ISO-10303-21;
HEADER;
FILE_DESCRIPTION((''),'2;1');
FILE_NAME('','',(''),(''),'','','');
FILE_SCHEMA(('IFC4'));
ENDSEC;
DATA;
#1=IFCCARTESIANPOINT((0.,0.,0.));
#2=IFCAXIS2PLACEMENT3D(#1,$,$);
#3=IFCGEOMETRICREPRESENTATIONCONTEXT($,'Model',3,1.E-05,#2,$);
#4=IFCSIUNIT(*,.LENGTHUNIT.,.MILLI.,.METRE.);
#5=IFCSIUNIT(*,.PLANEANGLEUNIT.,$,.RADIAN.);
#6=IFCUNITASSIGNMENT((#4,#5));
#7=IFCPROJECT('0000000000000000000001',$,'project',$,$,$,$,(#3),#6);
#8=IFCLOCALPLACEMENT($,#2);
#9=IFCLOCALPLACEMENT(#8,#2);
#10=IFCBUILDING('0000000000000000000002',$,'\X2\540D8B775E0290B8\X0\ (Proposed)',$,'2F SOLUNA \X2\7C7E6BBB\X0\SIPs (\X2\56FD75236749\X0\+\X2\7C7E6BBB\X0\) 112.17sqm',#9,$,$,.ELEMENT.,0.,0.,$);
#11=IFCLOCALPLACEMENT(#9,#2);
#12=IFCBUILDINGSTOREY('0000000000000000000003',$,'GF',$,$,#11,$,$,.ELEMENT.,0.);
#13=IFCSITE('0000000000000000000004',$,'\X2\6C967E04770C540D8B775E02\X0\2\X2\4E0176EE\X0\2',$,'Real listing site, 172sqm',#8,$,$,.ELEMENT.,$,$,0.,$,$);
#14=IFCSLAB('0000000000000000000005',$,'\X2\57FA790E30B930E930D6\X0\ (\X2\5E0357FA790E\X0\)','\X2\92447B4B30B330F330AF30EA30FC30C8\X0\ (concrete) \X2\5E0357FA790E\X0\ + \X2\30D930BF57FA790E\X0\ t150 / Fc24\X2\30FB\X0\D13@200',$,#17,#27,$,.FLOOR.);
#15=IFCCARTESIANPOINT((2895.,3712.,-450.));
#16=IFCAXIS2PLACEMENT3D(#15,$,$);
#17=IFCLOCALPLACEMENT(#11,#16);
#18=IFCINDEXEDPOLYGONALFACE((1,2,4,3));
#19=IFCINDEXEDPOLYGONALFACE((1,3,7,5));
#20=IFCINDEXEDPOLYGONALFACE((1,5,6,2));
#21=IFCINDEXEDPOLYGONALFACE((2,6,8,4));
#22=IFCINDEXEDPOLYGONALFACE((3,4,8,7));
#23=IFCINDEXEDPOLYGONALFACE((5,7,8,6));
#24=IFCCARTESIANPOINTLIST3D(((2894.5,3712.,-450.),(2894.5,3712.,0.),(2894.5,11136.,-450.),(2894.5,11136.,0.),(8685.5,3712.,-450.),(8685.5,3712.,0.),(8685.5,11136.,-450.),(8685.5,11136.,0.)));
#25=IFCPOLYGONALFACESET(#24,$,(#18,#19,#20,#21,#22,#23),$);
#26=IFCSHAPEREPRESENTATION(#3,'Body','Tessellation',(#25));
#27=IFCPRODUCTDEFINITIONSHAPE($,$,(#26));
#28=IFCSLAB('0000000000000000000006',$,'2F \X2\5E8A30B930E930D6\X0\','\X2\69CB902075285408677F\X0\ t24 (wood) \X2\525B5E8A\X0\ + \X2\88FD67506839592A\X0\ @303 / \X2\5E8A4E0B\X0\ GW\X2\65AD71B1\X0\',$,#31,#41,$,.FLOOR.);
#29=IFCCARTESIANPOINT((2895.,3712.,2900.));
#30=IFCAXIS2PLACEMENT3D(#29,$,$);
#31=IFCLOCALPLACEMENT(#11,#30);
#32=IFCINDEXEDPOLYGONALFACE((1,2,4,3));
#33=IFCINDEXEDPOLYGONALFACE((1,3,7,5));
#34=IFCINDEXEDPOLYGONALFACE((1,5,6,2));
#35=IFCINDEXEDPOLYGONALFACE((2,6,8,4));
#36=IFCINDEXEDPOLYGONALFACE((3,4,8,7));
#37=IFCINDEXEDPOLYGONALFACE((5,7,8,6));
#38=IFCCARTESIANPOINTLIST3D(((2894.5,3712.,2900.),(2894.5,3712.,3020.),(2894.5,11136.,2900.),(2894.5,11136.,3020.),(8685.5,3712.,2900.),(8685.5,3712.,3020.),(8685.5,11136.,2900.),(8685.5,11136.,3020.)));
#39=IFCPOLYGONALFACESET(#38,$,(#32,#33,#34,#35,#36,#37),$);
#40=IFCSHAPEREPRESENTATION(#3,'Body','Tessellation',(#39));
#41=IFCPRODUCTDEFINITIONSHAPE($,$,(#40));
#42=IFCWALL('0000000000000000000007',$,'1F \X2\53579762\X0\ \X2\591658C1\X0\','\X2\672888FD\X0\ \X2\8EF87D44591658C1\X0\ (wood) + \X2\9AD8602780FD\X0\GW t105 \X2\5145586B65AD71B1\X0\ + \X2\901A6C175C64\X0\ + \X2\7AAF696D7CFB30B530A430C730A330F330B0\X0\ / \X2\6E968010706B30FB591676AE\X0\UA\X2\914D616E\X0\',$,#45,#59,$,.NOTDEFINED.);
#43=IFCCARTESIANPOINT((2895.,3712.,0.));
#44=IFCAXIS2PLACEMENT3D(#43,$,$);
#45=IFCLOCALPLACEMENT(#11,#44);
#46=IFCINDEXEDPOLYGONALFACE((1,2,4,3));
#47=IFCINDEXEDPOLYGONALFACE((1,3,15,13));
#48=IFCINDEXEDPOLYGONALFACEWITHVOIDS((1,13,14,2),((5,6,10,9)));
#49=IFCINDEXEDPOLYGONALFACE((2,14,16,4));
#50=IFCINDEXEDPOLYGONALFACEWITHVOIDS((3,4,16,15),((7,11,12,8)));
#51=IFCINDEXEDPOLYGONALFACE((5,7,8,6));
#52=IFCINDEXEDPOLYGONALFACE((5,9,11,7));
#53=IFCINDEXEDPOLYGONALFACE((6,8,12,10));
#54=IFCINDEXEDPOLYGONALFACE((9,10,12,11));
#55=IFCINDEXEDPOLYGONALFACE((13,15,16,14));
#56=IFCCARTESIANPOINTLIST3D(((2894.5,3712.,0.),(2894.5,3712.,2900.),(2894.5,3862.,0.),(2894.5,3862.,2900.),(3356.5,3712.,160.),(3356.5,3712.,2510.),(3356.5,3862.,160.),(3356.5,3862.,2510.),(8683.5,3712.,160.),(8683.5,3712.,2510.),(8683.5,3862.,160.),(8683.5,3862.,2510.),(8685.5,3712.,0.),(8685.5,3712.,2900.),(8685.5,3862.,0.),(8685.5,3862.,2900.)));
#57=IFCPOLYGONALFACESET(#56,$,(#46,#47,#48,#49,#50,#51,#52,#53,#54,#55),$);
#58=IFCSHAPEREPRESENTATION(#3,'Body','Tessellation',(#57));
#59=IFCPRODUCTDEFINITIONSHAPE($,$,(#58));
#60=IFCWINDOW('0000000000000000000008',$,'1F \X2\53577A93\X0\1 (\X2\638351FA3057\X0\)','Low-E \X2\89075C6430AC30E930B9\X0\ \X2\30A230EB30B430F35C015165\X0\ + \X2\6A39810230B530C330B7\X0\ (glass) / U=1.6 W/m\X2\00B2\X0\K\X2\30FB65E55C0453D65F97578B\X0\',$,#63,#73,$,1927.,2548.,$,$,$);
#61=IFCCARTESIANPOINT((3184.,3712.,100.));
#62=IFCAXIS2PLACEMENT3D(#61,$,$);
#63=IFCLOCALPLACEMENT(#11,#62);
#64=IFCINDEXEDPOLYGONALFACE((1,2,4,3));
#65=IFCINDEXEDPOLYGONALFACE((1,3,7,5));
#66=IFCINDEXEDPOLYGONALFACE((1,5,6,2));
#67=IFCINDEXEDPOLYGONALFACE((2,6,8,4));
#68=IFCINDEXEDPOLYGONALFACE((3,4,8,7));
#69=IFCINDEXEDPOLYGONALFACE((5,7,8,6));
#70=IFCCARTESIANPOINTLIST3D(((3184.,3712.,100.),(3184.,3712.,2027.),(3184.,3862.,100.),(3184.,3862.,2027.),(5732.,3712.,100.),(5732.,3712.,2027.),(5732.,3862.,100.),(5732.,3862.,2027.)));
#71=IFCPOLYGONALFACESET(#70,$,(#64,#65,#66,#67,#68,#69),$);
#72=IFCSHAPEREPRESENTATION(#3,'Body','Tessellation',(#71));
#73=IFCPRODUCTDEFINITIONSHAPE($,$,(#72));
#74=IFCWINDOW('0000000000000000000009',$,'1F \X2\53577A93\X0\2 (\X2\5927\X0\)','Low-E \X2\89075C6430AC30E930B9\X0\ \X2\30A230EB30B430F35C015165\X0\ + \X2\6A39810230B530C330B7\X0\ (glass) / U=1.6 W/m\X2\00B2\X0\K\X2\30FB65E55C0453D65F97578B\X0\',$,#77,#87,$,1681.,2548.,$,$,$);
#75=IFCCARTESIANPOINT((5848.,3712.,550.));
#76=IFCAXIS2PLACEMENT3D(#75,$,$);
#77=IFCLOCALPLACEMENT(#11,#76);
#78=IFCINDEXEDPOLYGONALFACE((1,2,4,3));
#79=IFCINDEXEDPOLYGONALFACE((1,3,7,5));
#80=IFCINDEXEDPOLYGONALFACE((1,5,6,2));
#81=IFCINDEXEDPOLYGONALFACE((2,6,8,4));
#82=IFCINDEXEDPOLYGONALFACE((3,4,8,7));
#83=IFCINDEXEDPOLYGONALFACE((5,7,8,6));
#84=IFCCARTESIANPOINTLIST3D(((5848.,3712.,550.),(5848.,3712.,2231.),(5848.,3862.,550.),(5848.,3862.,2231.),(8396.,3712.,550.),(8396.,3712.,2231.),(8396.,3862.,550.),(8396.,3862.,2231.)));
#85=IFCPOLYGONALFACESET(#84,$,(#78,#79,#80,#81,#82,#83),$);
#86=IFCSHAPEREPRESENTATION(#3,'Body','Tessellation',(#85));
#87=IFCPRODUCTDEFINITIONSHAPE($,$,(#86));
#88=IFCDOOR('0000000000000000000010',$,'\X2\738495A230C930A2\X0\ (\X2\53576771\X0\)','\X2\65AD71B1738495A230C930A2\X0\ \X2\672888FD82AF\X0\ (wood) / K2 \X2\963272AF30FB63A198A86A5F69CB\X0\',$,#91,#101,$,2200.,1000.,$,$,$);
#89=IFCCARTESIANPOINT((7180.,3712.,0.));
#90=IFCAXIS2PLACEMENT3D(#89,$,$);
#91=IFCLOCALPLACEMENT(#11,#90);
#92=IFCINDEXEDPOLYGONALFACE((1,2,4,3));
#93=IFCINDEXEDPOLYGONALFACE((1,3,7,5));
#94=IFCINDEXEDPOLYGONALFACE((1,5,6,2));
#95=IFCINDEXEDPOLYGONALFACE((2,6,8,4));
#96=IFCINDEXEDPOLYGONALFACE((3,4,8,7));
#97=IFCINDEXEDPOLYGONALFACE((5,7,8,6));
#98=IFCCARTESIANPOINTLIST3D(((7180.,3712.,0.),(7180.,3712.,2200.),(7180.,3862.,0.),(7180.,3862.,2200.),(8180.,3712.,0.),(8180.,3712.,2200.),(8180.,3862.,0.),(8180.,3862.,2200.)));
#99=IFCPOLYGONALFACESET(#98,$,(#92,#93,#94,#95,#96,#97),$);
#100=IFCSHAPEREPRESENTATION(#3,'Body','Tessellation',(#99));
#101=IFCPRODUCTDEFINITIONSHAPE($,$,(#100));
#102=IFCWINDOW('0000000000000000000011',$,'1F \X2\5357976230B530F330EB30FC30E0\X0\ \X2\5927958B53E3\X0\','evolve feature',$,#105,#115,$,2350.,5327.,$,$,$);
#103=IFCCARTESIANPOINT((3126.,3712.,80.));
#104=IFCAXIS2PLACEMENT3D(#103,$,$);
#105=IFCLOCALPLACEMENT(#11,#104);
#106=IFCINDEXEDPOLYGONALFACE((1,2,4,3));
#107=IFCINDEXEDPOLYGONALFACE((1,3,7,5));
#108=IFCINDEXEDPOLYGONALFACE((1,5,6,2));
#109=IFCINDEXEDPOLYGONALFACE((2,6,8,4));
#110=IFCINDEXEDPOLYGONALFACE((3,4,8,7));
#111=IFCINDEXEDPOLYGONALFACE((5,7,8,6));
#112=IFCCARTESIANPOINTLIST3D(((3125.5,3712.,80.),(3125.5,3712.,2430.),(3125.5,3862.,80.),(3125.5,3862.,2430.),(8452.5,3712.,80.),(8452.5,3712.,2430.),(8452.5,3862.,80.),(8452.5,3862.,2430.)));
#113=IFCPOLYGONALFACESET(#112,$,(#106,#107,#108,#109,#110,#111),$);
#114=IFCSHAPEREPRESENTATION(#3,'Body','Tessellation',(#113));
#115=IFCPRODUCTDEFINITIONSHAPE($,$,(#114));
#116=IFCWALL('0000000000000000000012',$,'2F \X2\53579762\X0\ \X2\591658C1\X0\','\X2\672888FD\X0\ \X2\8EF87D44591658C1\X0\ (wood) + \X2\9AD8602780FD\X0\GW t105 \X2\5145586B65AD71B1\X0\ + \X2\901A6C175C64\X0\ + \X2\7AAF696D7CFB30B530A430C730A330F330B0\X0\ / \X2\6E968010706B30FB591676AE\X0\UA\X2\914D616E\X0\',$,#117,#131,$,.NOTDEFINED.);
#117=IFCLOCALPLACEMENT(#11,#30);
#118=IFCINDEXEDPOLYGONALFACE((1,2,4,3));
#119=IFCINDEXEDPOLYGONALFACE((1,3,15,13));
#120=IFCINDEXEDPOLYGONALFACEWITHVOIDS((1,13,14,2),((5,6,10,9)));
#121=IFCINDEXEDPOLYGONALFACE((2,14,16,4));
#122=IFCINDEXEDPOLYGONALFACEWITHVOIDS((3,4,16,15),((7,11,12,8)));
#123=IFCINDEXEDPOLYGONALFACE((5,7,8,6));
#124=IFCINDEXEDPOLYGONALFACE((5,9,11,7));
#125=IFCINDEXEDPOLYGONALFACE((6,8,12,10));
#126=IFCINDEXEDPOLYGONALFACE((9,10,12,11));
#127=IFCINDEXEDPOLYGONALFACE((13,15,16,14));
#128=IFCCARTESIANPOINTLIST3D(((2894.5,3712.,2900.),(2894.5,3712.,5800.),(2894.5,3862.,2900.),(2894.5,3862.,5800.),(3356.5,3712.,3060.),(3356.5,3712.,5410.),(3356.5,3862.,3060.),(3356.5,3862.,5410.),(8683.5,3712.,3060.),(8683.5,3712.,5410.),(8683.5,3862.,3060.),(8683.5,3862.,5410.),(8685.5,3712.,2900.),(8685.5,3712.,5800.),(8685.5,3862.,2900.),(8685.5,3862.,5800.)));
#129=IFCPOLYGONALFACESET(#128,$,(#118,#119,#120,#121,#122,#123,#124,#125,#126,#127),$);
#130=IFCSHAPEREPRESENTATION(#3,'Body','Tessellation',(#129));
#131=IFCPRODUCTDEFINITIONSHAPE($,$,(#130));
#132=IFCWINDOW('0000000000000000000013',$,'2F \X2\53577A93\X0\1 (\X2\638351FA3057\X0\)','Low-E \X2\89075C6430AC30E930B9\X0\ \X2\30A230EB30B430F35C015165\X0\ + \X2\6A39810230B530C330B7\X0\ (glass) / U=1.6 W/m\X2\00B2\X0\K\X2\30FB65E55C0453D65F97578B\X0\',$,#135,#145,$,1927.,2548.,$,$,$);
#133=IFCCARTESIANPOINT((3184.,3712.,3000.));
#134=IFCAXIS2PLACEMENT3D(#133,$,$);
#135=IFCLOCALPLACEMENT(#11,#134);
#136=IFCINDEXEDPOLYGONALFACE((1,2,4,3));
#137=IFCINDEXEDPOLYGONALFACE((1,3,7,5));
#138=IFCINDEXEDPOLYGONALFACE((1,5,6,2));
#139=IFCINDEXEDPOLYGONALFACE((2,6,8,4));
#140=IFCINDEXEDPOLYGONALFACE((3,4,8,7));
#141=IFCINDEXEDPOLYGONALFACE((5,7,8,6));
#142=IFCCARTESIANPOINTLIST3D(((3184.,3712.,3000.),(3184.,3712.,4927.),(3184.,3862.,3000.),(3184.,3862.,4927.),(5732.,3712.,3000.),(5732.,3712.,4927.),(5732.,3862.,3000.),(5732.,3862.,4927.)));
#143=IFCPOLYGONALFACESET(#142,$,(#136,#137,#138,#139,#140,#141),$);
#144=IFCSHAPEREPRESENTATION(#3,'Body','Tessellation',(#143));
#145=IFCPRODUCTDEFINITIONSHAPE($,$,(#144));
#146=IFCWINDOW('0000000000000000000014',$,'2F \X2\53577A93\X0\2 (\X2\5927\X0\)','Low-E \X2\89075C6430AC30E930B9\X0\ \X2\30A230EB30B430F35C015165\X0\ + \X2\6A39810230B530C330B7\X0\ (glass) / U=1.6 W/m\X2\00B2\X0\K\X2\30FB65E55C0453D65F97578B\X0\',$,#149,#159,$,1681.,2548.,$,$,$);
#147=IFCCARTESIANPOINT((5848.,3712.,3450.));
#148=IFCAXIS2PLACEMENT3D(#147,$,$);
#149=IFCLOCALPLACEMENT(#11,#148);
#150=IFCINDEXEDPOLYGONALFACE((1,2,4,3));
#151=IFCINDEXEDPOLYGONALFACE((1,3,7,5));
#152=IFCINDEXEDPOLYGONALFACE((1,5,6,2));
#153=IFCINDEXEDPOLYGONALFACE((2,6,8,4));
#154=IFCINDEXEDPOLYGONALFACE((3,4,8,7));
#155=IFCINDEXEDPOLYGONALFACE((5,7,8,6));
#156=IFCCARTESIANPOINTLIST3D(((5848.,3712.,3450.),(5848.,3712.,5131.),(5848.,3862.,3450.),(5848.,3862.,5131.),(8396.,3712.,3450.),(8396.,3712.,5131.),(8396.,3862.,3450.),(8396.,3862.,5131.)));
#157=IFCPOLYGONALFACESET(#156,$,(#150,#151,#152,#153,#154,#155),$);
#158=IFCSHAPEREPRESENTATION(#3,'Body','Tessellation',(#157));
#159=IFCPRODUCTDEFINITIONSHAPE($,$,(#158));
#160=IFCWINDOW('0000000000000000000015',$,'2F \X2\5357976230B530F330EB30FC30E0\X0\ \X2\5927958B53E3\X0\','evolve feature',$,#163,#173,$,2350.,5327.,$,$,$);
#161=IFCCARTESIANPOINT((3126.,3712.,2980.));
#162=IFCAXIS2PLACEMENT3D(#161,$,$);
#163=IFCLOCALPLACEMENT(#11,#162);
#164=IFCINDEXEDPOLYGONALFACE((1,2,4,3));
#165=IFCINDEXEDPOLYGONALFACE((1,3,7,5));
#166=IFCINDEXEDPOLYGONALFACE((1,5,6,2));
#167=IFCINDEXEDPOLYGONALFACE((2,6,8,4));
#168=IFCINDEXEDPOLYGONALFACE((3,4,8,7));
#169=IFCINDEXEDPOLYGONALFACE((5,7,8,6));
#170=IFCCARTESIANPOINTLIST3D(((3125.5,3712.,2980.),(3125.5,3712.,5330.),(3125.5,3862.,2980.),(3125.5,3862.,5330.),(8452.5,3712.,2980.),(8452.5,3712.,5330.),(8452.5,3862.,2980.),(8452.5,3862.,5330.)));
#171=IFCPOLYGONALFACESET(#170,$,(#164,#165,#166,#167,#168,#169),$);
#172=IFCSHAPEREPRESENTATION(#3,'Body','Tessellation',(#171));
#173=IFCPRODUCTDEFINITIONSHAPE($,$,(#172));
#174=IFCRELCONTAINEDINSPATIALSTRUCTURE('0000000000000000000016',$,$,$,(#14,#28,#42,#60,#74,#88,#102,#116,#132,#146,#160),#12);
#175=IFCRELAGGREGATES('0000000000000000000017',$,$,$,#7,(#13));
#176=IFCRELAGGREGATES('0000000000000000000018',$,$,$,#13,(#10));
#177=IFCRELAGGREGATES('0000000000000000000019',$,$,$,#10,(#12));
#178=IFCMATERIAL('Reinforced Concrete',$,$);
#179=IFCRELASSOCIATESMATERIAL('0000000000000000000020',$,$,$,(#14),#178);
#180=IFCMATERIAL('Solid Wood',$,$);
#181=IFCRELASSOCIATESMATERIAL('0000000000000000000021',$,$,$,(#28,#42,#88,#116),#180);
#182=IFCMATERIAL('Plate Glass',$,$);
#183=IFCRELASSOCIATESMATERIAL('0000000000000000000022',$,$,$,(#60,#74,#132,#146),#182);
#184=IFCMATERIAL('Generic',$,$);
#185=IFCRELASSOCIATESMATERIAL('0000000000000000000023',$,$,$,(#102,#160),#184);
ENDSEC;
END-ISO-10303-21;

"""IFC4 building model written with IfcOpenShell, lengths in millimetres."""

from ifc_helpers import new_model, si_unit, frame, frame_2d, origin, place, context, project, spatial, rectangle, extrude, material, element, fill, save


model = new_model("IFC4")

# Units and contexts
model_context = context("Model", 3, precision=1e-05, world=origin())
ifc_project = project(units=[si_unit("LENGTHUNIT", "METRE", prefix="MILLI"), si_unit("PLANEANGLEUNIT", "RADIAN")], contexts=[model_context])

# Site, building, storey
site_placement = place(None, origin())
site = spatial("IfcSite", under=ifc_project, at=site_placement, Name="沖縄県名護市2丁目2", ObjectType="Real listing site, 172sqm", CompositionType="ELEMENT", RefElevation=0.0)
building_placement = place(site_placement, origin())
building = spatial("IfcBuilding", under=site, at=building_placement, Name="名護市邸 (Proposed)", ObjectType="2F SOLUNA 籾殻SIPs (国産杉+籾殻) 112.17sqm", CompositionType="ELEMENT", ElevationOfRefHeight=0.0, ElevationOfTerrain=0.0)
storey_placement = place(building_placement, origin())
storey = spatial("IfcBuildingStorey", under=building, at=storey_placement, Name="GF", CompositionType="ELEMENT", Elevation=0.0)

# Slabs
ifc_material_1 = material(Name="Reinforced Concrete")
slab_1_placement = place(storey_placement, frame((2895.0, 3712.0, -450.0)))
element("IfcSlab", 1, at=slab_1_placement, inside=storey, material=ifc_material_1, Name="基礎スラブ (布基礎)", Description="鉄筋コンクリート (concrete) 布基礎 + ベタ基礎 t150 / Fc24・D13@200", PredefinedType="FLOOR", context=model_context, shape_type="SweptSolid", body=[
    extrude(rectangle(XDim=5791.0, YDim=7424.0, at=frame_2d((2895.0, 3712.0))), frame((2895.0, 3712.0, -450.0)), (0.0, 0.0, 1.0), 450.0),
])
ifc_material_2 = material(Name="Solid Wood")
slab_2_placement = place(storey_placement, frame((2895.0, 3712.0, 2900.0)))
element("IfcSlab", 2, at=slab_2_placement, inside=storey, material=ifc_material_2, Name="2F 床スラブ", Description="構造用合板 t24 (wood) 剛床 + 製材根太 @303 / 床下 GW断熱", PredefinedType="FLOOR", context=model_context, shape_type="SweptSolid", body=[
    extrude(rectangle(XDim=5791.0, YDim=7424.0, at=frame_2d((2895.0, 3712.0))), frame((2895.0, 3712.0, 2900.0)), (0.0, 0.0, 1.0), 120.0),
])
ifc_material_3 = material(Name="Generic")

# Wall, openings, windows, door
wall_1_placement = place(storey_placement, frame((2895.0, 3712.0, 0.0)))
wall_1 = element("IfcWall", 3, at=wall_1_placement, inside=storey, material=ifc_material_2, Name="1F 南面 外壁", Description="木製 軸組外壁 (wood) + 高性能GW t105 充填断熱 + 通気層 + 窯業系サイディング / 準耐火・外皮UA配慮", PredefinedType="NOTDEFINED", context=model_context, shape_type="SweptSolid", body=[
    extrude(rectangle(XDim=5791.0, YDim=150.0, at=frame_2d((2895.0, 75.0))), frame((2895.0, 3712.0, 0.0)), (0.0, 0.0, 1.0), 2900.0),
])
opening_1_placement = place(storey_placement, frame((3184.0, 3712.0, 100.0)))
opening_1 = element("IfcOpeningElement", 4, at=opening_1_placement, cuts=wall_1, PredefinedType="NOTDEFINED", context=model_context, shape_type="SweptSolid", body=[
    extrude(rectangle(XDim=2548.0, YDim=150.0, at=frame_2d((1274.0, 75.0))), frame((3184.0, 3712.0, 100.0)), (0.0, 0.0, 1.0), 1927.0),
])
opening_2_placement = place(storey_placement, frame((5848.0, 3712.0, 550.0)))
opening_2 = element("IfcOpeningElement", 5, at=opening_2_placement, cuts=wall_1, PredefinedType="NOTDEFINED", context=model_context, shape_type="SweptSolid", body=[
    extrude(rectangle(XDim=2548.0, YDim=150.0, at=frame_2d((1274.0, 75.0))), frame((5848.0, 3712.0, 550.0)), (0.0, 0.0, 1.0), 1681.0),
])
opening_3_placement = place(storey_placement, frame((7180.0, 3712.0, 0.0)))
opening_3 = element("IfcOpeningElement", 6, at=opening_3_placement, cuts=wall_1, PredefinedType="NOTDEFINED", context=model_context, shape_type="SweptSolid", body=[
    extrude(rectangle(XDim=1000.0, YDim=150.0, at=frame_2d((500.0, 75.0))), frame((7180.0, 3712.0, 0.0)), (0.0, 0.0, 1.0), 2200.0),
])
opening_4_placement = place(storey_placement, frame((3126.0, 3712.0, 80.0)))
opening_4 = element("IfcOpeningElement", 7, at=opening_4_placement, cuts=wall_1, PredefinedType="NOTDEFINED", context=model_context, shape_type="SweptSolid", body=[
    extrude(rectangle(XDim=5327.0, YDim=150.0, at=frame_2d((2663.0, 75.0))), frame((3126.0, 3712.0, 80.0)), (0.0, 0.0, 1.0), 2350.0),
])
ifc_material_4 = material(Name="Plate Glass")
window_1_placement = place(storey_placement, frame((3184.0, 3712.0, 100.0)))
window_1 = element("IfcWindow", 8, at=window_1_placement, inside=storey, material=ifc_material_4, Name="1F 南窓1 (掃出し)", Description="Low-E 複層ガラス アルゴン封入 + 樹脂サッシ (glass) / U=1.6 W/m²K・日射取得型", OverallHeight=1927.0, OverallWidth=2548.0, context=model_context, shape_type="SweptSolid", body=[
    extrude(rectangle(XDim=2548.0, YDim=150.0, at=frame_2d((1274.0, 75.0))), frame((3184.0, 3712.0, 100.0)), (0.0, 0.0, 1.0), 1927.0),
])
fill(opening_1, window_1)
window_2_placement = place(storey_placement, frame((5848.0, 3712.0, 550.0)))
window_2 = element("IfcWindow", 9, at=window_2_placement, inside=storey, material=ifc_material_4, Name="1F 南窓2 (大)", Description="Low-E 複層ガラス アルゴン封入 + 樹脂サッシ (glass) / U=1.6 W/m²K・日射取得型", OverallHeight=1681.0, OverallWidth=2548.0, context=model_context, shape_type="SweptSolid", body=[
    extrude(rectangle(XDim=2548.0, YDim=150.0, at=frame_2d((1274.0, 75.0))), frame((5848.0, 3712.0, 550.0)), (0.0, 0.0, 1.0), 1681.0),
])
fill(opening_2, window_2)
door_placement = place(storey_placement, frame((7180.0, 3712.0, 0.0)))
door = element("IfcDoor", 10, at=door_placement, inside=storey, material=ifc_material_2, Name="玄関ドア (南東)", Description="断熱玄関ドア 木製芯 (wood) / K2 防犯・採風機構", OverallHeight=2200.0, OverallWidth=1000.0, context=model_context, shape_type="SweptSolid", body=[
    extrude(rectangle(XDim=1000.0, YDim=150.0, at=frame_2d((500.0, 75.0))), frame((7180.0, 3712.0, 0.0)), (0.0, 0.0, 1.0), 2200.0),
])
fill(opening_3, door)
window_3_placement = place(storey_placement, frame((3126.0, 3712.0, 80.0)))
window_3 = element("IfcWindow", 11, at=window_3_placement, inside=storey, material=ifc_material_3, Name="1F 南面サンルーム 大開口", Description="evolve feature", OverallHeight=2350.0, OverallWidth=5327.0, context=model_context, shape_type="SweptSolid", body=[
    extrude(rectangle(XDim=5327.0, YDim=150.0, at=frame_2d((2663.0, 75.0))), frame((3126.0, 3712.0, 80.0)), (0.0, 0.0, 1.0), 2350.0),
])
fill(opening_4, window_3)

# Wall, openings, windows
wall_2_placement = place(storey_placement, frame((2895.0, 3712.0, 2900.0)))
wall_2 = element("IfcWall", 12, at=wall_2_placement, inside=storey, material=ifc_material_2, Name="2F 南面 外壁", Description="木製 軸組外壁 (wood) + 高性能GW t105 充填断熱 + 通気層 + 窯業系サイディング / 準耐火・外皮UA配慮", PredefinedType="NOTDEFINED", context=model_context, shape_type="SweptSolid", body=[
    extrude(rectangle(XDim=5791.0, YDim=150.0, at=frame_2d((2895.0, 75.0))), frame((2895.0, 3712.0, 2900.0)), (0.0, 0.0, 1.0), 2900.0),
])
opening_5_placement = place(storey_placement, frame((3184.0, 3712.0, 3000.0)))
opening_5 = element("IfcOpeningElement", 13, at=opening_5_placement, cuts=wall_2, PredefinedType="NOTDEFINED", context=model_context, shape_type="SweptSolid", body=[
    extrude(rectangle(XDim=2548.0, YDim=150.0, at=frame_2d((1274.0, 75.0))), frame((3184.0, 3712.0, 3000.0)), (0.0, 0.0, 1.0), 1927.0),
])
opening_6_placement = place(storey_placement, frame((5848.0, 3712.0, 3450.0)))
opening_6 = element("IfcOpeningElement", 14, at=opening_6_placement, cuts=wall_2, PredefinedType="NOTDEFINED", context=model_context, shape_type="SweptSolid", body=[
    extrude(rectangle(XDim=2548.0, YDim=150.0, at=frame_2d((1274.0, 75.0))), frame((5848.0, 3712.0, 3450.0)), (0.0, 0.0, 1.0), 1681.0),
])
opening_7_placement = place(storey_placement, frame((3126.0, 3712.0, 2980.0)))
opening_7 = element("IfcOpeningElement", 15, at=opening_7_placement, cuts=wall_2, PredefinedType="NOTDEFINED", context=model_context, shape_type="SweptSolid", body=[
    extrude(rectangle(XDim=5327.0, YDim=150.0, at=frame_2d((2663.0, 75.0))), frame((3126.0, 3712.0, 2980.0)), (0.0, 0.0, 1.0), 2350.0),
])
window_4_placement = place(storey_placement, frame((3184.0, 3712.0, 3000.0)))
window_4 = element("IfcWindow", 16, at=window_4_placement, inside=storey, material=ifc_material_4, Name="2F 南窓1 (掃出し)", Description="Low-E 複層ガラス アルゴン封入 + 樹脂サッシ (glass) / U=1.6 W/m²K・日射取得型", OverallHeight=1927.0, OverallWidth=2548.0, context=model_context, shape_type="SweptSolid", body=[
    extrude(rectangle(XDim=2548.0, YDim=150.0, at=frame_2d((1274.0, 75.0))), frame((3184.0, 3712.0, 3000.0)), (0.0, 0.0, 1.0), 1927.0),
])
fill(opening_5, window_4)
window_5_placement = place(storey_placement, frame((5848.0, 3712.0, 3450.0)))
window_5 = element("IfcWindow", 17, at=window_5_placement, inside=storey, material=ifc_material_4, Name="2F 南窓2 (大)", Description="Low-E 複層ガラス アルゴン封入 + 樹脂サッシ (glass) / U=1.6 W/m²K・日射取得型", OverallHeight=1681.0, OverallWidth=2548.0, context=model_context, shape_type="SweptSolid", body=[
    extrude(rectangle(XDim=2548.0, YDim=150.0, at=frame_2d((1274.0, 75.0))), frame((5848.0, 3712.0, 3450.0)), (0.0, 0.0, 1.0), 1681.0),
])
fill(opening_6, window_5)
window_6_placement = place(storey_placement, frame((3126.0, 3712.0, 2980.0)))
window_6 = element("IfcWindow", 18, at=window_6_placement, inside=storey, material=ifc_material_3, Name="2F 南面サンルーム 大開口", Description="evolve feature", OverallHeight=2350.0, OverallWidth=5327.0, context=model_context, shape_type="SweptSolid", body=[
    extrude(rectangle(XDim=5327.0, YDim=150.0, at=frame_2d((2663.0, 75.0))), frame((3126.0, 3712.0, 2980.0)), (0.0, 0.0, 1.0), 2350.0),
])
fill(opening_7, window_6)

save(model, "model.ifc")
